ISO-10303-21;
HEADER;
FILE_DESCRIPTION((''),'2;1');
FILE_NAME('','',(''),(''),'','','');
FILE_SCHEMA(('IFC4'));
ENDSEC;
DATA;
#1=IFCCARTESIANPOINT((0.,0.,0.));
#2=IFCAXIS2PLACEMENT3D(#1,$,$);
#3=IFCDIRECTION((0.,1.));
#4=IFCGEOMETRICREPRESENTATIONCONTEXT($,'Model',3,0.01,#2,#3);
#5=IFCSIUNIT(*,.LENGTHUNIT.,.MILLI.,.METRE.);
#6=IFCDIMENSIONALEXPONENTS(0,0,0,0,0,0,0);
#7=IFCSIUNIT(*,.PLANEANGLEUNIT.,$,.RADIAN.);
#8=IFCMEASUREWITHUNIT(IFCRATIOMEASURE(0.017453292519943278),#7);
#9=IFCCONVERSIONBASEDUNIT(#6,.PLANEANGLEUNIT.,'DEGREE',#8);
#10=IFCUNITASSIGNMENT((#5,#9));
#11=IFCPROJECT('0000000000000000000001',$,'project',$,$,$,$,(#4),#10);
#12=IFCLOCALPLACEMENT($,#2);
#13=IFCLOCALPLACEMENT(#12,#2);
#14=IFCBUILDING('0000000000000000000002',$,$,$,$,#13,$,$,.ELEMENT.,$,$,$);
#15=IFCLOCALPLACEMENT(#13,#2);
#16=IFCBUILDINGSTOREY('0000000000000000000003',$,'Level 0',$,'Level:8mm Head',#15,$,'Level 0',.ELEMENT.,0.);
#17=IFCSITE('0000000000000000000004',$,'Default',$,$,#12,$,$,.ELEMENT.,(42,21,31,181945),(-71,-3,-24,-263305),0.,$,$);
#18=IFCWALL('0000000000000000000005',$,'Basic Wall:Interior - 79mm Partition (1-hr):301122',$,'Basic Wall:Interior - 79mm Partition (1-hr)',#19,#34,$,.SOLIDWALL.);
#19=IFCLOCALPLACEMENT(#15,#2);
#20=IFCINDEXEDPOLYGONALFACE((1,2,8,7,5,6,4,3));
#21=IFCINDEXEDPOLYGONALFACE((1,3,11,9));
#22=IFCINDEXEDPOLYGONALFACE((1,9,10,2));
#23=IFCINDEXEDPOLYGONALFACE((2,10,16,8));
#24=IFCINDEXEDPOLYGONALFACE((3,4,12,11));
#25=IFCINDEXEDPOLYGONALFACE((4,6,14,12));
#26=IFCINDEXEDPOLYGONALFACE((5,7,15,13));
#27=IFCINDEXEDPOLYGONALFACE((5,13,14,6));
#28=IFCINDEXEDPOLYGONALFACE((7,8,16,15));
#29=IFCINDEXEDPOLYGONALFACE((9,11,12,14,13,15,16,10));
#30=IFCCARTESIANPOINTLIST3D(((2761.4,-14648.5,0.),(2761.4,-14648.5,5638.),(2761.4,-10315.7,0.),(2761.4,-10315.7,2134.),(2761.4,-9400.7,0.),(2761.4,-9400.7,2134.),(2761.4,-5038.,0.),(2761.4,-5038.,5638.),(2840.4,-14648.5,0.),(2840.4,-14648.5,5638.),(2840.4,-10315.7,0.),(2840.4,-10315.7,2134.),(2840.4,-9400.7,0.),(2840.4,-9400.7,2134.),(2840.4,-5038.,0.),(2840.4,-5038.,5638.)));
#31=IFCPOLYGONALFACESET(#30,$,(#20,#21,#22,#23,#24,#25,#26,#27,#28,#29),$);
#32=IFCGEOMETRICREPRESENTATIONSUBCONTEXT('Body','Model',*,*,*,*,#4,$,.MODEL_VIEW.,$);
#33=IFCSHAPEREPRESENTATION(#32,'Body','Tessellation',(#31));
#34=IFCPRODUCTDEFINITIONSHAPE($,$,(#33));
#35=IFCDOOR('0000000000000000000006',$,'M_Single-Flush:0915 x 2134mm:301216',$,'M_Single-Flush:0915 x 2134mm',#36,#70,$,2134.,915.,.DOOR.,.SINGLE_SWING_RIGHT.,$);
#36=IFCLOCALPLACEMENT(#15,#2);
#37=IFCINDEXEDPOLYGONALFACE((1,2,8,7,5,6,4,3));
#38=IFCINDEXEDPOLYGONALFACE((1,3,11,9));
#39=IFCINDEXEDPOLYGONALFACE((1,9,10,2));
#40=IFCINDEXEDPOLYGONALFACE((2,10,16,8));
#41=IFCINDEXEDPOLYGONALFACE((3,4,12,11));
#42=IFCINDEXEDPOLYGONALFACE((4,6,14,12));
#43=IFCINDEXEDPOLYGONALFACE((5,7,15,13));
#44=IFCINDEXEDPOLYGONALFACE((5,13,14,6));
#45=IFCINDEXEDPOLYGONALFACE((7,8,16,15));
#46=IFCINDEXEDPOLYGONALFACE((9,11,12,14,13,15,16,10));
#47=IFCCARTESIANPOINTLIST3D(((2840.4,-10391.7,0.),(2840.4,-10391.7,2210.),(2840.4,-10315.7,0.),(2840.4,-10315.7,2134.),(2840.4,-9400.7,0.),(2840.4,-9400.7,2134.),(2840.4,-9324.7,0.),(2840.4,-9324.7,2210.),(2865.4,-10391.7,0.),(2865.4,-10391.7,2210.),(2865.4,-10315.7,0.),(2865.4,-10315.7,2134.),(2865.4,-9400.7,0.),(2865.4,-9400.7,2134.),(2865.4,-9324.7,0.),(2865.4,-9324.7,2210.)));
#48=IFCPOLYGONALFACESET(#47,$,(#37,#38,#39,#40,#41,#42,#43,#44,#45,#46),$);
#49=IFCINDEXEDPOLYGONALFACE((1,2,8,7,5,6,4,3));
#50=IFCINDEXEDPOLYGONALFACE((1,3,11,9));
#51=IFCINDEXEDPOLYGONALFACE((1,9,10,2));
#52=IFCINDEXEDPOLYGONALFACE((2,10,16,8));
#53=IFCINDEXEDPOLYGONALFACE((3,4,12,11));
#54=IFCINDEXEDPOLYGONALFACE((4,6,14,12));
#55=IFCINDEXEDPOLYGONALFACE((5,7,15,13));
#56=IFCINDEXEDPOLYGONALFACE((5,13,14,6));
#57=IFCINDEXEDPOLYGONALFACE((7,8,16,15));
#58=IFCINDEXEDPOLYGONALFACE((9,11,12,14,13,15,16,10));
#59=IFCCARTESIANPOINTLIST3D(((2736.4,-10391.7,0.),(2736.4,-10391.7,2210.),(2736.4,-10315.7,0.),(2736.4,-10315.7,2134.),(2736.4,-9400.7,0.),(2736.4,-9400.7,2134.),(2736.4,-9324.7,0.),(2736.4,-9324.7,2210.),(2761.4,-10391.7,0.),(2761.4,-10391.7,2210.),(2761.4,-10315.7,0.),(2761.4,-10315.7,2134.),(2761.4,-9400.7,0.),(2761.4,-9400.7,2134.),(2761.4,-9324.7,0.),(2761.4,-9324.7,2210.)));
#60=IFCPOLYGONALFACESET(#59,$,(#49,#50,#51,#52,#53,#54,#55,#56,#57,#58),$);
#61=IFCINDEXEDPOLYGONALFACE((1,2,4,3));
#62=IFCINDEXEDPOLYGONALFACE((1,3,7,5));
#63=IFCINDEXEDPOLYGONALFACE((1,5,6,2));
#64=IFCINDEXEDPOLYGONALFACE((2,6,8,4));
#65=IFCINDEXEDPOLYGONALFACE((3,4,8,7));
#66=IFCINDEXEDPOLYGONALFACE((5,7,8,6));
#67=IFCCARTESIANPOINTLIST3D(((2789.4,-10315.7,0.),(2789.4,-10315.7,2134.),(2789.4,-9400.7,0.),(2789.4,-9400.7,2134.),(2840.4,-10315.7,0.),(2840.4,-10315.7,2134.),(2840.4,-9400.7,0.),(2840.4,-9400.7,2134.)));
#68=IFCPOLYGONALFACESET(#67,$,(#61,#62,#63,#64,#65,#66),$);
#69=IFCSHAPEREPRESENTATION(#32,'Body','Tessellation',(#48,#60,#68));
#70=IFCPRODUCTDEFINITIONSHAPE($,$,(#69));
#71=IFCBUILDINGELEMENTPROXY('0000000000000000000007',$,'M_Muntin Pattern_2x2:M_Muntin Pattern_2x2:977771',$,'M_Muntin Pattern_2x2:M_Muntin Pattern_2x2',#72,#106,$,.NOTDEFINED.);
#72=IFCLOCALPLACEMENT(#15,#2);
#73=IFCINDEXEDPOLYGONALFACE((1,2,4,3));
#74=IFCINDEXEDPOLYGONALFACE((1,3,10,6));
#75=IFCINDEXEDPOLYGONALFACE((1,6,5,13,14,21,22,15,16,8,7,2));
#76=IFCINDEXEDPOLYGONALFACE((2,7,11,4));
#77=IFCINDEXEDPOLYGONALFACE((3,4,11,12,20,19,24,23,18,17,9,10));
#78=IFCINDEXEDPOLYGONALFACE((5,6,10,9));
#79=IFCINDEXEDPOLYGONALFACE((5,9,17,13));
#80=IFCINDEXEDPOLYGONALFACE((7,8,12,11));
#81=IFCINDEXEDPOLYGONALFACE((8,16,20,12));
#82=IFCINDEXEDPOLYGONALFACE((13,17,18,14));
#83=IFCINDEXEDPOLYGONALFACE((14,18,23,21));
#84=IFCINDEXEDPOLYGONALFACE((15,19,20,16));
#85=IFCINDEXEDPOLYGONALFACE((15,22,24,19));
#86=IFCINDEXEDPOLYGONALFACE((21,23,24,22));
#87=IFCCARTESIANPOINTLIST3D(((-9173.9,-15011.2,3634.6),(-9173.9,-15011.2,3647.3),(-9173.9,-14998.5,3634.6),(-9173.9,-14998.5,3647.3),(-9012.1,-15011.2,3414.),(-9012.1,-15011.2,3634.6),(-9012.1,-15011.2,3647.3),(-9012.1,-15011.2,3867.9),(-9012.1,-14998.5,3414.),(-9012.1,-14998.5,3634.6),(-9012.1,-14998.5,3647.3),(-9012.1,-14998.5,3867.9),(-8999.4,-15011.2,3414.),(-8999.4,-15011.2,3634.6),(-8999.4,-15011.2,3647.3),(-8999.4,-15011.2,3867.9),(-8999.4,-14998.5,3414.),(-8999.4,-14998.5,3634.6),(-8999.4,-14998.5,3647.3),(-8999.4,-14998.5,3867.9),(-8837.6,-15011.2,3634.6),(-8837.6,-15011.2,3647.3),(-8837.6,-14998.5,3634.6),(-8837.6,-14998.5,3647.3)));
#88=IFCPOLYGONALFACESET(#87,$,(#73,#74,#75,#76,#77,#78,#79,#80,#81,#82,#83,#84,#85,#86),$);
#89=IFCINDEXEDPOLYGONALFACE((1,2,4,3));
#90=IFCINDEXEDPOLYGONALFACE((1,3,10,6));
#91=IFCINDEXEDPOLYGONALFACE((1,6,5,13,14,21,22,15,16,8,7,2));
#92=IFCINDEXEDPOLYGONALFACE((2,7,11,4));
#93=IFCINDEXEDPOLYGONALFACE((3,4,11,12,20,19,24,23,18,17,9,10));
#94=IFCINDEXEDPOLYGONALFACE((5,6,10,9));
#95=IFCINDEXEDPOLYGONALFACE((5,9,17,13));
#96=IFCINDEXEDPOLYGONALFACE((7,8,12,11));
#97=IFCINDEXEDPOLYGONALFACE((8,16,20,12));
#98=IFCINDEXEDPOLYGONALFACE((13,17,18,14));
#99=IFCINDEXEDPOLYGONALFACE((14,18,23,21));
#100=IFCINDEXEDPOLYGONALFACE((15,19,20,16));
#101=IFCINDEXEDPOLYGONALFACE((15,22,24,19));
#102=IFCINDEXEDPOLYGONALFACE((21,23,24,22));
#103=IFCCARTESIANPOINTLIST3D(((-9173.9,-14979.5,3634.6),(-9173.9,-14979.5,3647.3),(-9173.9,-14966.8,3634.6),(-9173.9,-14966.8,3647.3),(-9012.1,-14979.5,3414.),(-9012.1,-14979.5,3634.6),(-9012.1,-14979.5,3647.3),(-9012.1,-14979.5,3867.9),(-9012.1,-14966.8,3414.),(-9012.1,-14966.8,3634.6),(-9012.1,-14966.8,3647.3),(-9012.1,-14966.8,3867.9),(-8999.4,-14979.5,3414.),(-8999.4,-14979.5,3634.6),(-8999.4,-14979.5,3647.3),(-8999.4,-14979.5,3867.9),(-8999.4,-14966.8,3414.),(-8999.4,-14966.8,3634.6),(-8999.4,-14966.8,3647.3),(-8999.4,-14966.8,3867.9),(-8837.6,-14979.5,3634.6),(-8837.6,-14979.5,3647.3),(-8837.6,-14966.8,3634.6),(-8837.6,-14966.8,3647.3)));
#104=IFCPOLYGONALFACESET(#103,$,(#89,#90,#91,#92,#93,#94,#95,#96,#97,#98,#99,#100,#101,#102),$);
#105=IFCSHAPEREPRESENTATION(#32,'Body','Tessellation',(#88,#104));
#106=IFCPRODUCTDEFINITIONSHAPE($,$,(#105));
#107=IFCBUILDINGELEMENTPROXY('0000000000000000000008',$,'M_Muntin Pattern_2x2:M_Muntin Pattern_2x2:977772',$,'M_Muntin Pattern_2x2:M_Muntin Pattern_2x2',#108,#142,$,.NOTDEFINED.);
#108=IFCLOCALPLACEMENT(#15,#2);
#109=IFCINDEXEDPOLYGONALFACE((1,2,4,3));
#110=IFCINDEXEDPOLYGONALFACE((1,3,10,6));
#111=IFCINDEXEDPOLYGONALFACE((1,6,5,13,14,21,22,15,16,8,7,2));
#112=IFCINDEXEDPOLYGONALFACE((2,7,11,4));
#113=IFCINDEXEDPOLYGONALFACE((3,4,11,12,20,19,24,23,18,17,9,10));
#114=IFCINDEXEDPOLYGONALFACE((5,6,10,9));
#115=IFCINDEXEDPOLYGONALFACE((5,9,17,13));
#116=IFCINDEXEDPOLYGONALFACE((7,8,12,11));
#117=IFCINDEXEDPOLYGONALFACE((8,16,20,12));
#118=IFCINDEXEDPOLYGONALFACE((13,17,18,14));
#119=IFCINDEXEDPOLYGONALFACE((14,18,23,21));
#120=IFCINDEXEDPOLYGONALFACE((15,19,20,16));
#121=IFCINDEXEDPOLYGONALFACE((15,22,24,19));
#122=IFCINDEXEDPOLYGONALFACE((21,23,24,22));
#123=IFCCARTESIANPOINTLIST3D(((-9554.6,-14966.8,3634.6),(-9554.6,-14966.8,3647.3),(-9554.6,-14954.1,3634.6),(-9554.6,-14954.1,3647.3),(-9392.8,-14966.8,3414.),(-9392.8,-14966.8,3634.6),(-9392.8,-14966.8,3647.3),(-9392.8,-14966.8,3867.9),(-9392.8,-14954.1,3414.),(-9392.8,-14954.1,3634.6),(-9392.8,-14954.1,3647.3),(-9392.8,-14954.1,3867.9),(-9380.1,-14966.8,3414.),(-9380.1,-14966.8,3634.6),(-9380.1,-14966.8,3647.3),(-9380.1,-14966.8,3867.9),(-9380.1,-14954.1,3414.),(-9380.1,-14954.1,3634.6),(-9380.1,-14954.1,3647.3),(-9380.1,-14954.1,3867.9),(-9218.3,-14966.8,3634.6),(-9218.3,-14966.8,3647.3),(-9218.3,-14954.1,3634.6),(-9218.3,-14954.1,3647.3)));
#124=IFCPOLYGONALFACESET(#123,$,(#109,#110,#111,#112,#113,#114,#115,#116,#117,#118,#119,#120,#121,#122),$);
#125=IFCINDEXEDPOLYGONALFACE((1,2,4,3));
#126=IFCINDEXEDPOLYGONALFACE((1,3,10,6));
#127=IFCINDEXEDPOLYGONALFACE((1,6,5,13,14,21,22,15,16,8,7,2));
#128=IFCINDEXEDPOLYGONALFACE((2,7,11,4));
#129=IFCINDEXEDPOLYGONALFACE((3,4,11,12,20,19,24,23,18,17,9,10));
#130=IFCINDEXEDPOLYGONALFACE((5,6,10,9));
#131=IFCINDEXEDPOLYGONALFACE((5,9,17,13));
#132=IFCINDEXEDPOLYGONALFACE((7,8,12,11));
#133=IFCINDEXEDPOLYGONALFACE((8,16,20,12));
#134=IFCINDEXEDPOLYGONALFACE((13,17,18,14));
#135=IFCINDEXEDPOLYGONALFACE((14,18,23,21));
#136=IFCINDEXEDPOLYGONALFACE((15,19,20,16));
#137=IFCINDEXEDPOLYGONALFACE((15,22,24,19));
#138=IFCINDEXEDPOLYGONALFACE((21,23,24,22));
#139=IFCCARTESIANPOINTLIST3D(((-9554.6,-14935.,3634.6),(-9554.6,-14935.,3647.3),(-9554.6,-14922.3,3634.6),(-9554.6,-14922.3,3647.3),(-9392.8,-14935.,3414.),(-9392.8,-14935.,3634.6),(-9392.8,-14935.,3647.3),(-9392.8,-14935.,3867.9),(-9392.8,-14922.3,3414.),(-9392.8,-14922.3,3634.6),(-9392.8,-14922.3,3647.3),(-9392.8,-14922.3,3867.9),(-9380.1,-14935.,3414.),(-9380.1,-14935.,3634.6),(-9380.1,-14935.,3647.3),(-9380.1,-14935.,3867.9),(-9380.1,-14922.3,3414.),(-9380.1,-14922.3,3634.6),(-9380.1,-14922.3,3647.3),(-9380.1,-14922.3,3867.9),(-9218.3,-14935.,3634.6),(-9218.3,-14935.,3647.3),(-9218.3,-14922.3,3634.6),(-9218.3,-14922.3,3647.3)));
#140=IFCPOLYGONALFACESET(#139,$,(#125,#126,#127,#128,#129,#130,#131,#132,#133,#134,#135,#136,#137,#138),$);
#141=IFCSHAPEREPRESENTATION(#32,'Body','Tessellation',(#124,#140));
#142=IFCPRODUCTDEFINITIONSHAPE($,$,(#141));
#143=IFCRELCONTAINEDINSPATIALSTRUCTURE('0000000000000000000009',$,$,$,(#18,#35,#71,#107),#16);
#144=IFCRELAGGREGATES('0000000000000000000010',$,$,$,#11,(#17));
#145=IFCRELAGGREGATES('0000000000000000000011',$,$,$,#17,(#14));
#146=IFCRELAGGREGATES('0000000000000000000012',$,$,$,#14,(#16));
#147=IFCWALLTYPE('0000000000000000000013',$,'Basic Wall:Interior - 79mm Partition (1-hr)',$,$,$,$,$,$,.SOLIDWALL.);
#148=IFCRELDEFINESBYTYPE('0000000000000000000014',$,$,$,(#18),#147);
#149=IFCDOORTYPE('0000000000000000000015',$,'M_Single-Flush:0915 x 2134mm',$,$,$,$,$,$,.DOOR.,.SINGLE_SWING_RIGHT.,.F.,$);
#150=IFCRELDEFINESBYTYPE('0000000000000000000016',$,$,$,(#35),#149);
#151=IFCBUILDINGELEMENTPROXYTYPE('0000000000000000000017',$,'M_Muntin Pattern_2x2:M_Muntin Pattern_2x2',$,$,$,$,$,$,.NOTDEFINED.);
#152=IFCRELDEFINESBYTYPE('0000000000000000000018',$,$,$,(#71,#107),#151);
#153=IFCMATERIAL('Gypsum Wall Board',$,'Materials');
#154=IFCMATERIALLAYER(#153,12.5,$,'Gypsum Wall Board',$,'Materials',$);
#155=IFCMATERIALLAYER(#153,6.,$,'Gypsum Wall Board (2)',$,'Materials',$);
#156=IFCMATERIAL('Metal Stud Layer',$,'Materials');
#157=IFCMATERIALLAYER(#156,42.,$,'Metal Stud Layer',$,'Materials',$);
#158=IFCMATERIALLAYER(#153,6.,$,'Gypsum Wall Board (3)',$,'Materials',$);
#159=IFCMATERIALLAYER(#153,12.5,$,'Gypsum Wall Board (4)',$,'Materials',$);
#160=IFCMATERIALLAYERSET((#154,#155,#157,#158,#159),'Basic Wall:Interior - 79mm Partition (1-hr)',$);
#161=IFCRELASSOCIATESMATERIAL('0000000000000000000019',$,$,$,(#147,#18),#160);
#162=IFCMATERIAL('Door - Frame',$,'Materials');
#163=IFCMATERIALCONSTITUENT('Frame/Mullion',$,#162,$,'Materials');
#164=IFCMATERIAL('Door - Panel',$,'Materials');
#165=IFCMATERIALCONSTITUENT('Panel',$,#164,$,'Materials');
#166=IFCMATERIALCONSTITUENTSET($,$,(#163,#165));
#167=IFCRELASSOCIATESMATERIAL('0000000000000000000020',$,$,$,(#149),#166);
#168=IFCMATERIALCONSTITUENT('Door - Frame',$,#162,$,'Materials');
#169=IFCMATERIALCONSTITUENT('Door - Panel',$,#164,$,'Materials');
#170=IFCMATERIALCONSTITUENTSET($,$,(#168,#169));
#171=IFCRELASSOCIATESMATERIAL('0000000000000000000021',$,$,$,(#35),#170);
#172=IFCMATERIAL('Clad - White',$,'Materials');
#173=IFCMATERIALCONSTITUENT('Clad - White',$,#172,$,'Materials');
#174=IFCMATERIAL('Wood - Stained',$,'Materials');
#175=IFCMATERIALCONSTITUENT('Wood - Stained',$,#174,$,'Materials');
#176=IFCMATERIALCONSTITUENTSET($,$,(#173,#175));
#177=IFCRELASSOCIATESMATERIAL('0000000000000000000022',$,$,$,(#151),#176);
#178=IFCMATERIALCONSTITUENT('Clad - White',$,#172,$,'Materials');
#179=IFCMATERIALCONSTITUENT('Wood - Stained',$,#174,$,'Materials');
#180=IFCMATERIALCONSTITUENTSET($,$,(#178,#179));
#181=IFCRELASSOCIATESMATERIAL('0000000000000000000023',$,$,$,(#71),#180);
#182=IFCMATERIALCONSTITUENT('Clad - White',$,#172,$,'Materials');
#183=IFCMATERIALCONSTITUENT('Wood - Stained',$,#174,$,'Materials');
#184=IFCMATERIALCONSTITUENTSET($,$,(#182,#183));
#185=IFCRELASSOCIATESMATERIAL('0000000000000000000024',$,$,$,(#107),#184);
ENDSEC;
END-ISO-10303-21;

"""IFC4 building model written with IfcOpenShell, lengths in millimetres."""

from ifc_helpers import new_model, entity, si_unit, converted_unit, direction, frame, frame_2d, origin, origin_2d_with_axis, place, context, subcontext, project, spatial, polyline, rectangle, outline, extrude, clip, bounded_halfspace, source, transform, mapped, material, layer, layer_set, layer_usage, constituent, constituent_set, type_object, type_shapes, element, fill, save


model = new_model("IFC4")

# Units and contexts
model_context = context("Model", 3, precision=0.01, world=origin(), true_north=direction((0.0, 1.0)))
body_context = subcontext(model_context, "Body", "Model", "MODEL_VIEW")
ifc_project = project(units=[si_unit("LENGTHUNIT", "METRE", prefix="MILLI"), converted_unit("PLANEANGLEUNIT", "DEGREE", entity("IfcRatioMeasure", 0.017453292519943278), si_unit("PLANEANGLEUNIT", "RADIAN"), dimensions=[0, 0, 0, 0, 0, 0, 0])], contexts=[model_context])

# Site, building, storey
site_placement = place(None, origin())
site = spatial("IfcSite", under=ifc_project, at=site_placement, Name="Default", CompositionType="ELEMENT", RefLatitude=(42, 21, 31, 181945), RefLongitude=(-71, -3, -24, -263305), RefElevation=0.0)
building_placement = place(site_placement, origin())
building = spatial("IfcBuilding", under=site, at=building_placement, CompositionType="ELEMENT")
storey_placement = place(building_placement, origin())
storey = spatial("IfcBuildingStorey", under=building, at=storey_placement, Name="Level 0", ObjectType="Level:8mm Head", LongName="Level 0", CompositionType="ELEMENT", Elevation=0.0)

# Shared definitions
ifc_material_1 = material(Name="Metal Stud Layer", Category="Materials")
ifc_material_2 = material(Name="Gypsum Wall Board", Category="Materials")
ifc_material_3 = material(Name="Door - Frame", Category="Materials")
ifc_material_4 = material(Name="Door - Panel", Category="Materials")

# Wall, opening, door
ifc_layer_1 = layer(ifc_material_2, 12.5, Name="Gypsum Wall Board", Category="Materials")
ifc_layer_2 = layer(ifc_material_2, 6.0, Name="Gypsum Wall Board (2)", Category="Materials")
ifc_layer_3 = layer(ifc_material_1, 42.0, Name="Metal Stud Layer", Category="Materials")
ifc_layer_4 = layer(ifc_material_2, 6.0, Name="Gypsum Wall Board (3)", Category="Materials")
ifc_layer_5 = layer(ifc_material_2, 12.5, Name="Gypsum Wall Board (4)", Category="Materials")
ifc_layer_set_1 = layer_set([ifc_layer_1, ifc_layer_2, ifc_layer_3, ifc_layer_4, ifc_layer_5], Name="Basic Wall:Interior - 79mm Partition (1-hr)")
ifc_layer_usage_1 = layer_usage(ifc_layer_set_1, "AXIS2", "NEGATIVE", 39.5)
wall_type_1 = type_object("IfcWallType", Name="Basic Wall:Interior - 79mm Partition (1-hr)", PredefinedType="SOLIDWALL", material=ifc_layer_set_1)
ifc_constituent_1 = constituent(ifc_material_3, Name="Frame/Mullion", Category="Materials")
ifc_constituent_2 = constituent(ifc_material_4, Name="Panel", Category="Materials")
ifc_constituent_set_1 = constituent_set(constituents=[ifc_constituent_1, ifc_constituent_2])
door_type_1 = type_object("IfcDoorType", Name="M_Single-Flush:0915 x 2134mm", OperationType="SINGLE_SWING_RIGHT", ParameterTakesPrecedence=False, PredefinedType="DOOR", material=ifc_constituent_set_1)
shared_shape_1 = source(origin(), body_context, "Body", "SweptSolid", [
    extrude(outline(polyline([(-533.5, -1124.0), (533.5, -1124.0), (533.5, 1086.0), (457.5, 1086.0), (457.5, -1048.0), (-457.5, -1048.0), (-457.5, 1086.0), (-533.5, 1086.0), (-533.5, -1124.0)])), frame((457.5, 79.0, 1086.0), z_axis=(0.0, 1.0, 0.0), x_axis=(1.0, 0.0, 0.0)), (0.0, 0.0, 1.0), 25.0),
    extrude(outline(polyline([(-1124.0, -533.5), (1086.0, -533.5), (1086.0, -457.5), (-1048.0, -457.5), (-1048.0, 457.5), (1086.0, 457.5), (1086.0, 533.5), (-1124.0, 533.5), (-1124.0, -533.5)])), frame((457.5, -25.0, 1086.0), z_axis=(0.0, 1.0, 0.0), x_axis=(0.0, 0.0, -1.0)), (0.0, 0.0, 1.0), 25.0),
    extrude(rectangle(XDim=51.0, YDim=915.0, at=origin_2d_with_axis()), frame((457.5, 53.5, 0.0), z_axis=(0.0, 0.0, 1.0), x_axis=(0.0, 1.0, 0.0)), (0.0, 0.0, 1.0), 2134.0),
])
type_shapes(door_type_1, [shared_shape_1])
wall_1_placement = place(storey_placement, frame((2800.9, -5038.0, 0.0), z_axis=(0.0, 0.0, 1.0), x_axis=(0.0, -1.0, 0.0)))
wall_1 = element("IfcWall", 1, at=wall_1_placement, inside=storey, type_object=wall_type_1, material=ifc_layer_usage_1, Name="Basic Wall:Interior - 79mm Partition (1-hr):301122", ObjectType="Basic Wall:Interior - 79mm Partition (1-hr)", PredefinedType="SOLIDWALL", context=body_context, shape_type="Clipping", body=[
    clip(extrude(rectangle(XDim=9610.5, YDim=79.0, at=frame_2d((4805.3, 0.0), x_axis=(-1.0, 0.0))), origin(), (0.0, 0.0, 1.0), 5638.0), bounded_halfspace(frame((0.0, -39.5, 5638.0), z_axis=(0.0, 0.0, -1.0), x_axis=(1.0, 0.0, 0.0)), True, frame((0.0, -39.5, 5638.0)), polyline([(0.0, 0.0), (2929280.4, 0.0), (2929280.4, 24079.2), (0.0, 24079.2), (0.0, 0.0)]))),
])
opening_1_placement = place(wall_1_placement, frame((4362.6, -39.5, 0.0)))
opening_1 = element("IfcOpeningElement", 2, at=opening_1_placement, cuts=wall_1, PredefinedType="OPENING", context=body_context, shape_type="SweptSolid", body=[
    extrude(rectangle(XDim=915.0, YDim=2134.0, at=frame_2d((1067.0, 457.5), x_axis=(0.0, 1.0))), frame((0.0, 0.0, 0.0), z_axis=(0.0, 1.0, 0.0), x_axis=(0.0, 0.0, 1.0)), (0.0, 0.0, 1.0), 79.0),
])
ifc_constituent_3 = constituent(ifc_material_3, Name="Door - Frame", Category="Materials")
ifc_constituent_4 = constituent(ifc_material_4, Name="Door - Panel", Category="Materials")
ifc_constituent_set_2 = constituent_set(constituents=[ifc_constituent_3, ifc_constituent_4])
door_1_placement = place(opening_1_placement, origin())
door_1 = element("IfcDoor", 3, at=door_1_placement, inside=storey, type_object=door_type_1, material=ifc_constituent_set_2, Name="M_Single-Flush:0915 x 2134mm:301216", ObjectType="M_Single-Flush:0915 x 2134mm", OperationType="SINGLE_SWING_RIGHT", OverallHeight=2134.0, OverallWidth=915.0, PredefinedType="DOOR", context=body_context, shape_type="MappedRepresentation", body=[
    mapped(shared_shape_1, transform((0.0, 0.0, 0.0), scale=1.0)),
])
fill(opening_1, door_1)

# Building element proxies
ifc_material_5 = material(Name="Clad - White", Category="Materials")
ifc_constituent_5 = constituent(ifc_material_5, Name="Clad - White", Category="Materials")
ifc_material_6 = material(Name="Wood - Stained", Category="Materials")
ifc_constituent_6 = constituent(ifc_material_6, Name="Wood - Stained", Category="Materials")
ifc_constituent_set_3 = constituent_set(constituents=[ifc_constituent_5, ifc_constituent_6])
ifc_constituent_7 = constituent(ifc_material_5, Name="Clad - White", Category="Materials")
ifc_constituent_8 = constituent(ifc_material_6, Name="Wood - Stained", Category="Materials")
ifc_constituent_set_4 = constituent_set(constituents=[ifc_constituent_7, ifc_constituent_8])
building_element_proxy_type_1 = type_object("IfcBuildingElementProxyType", Name="M_Muntin Pattern_2x2:M_Muntin Pattern_2x2", PredefinedType="NOTDEFINED", material=ifc_constituent_set_4)
shared_shape_2 = source(origin(), body_context, "Body", "SweptSolid", [
    extrude(outline(polyline([(6.4, -6.4), (227.0, -6.4), (227.0, 6.3), (6.4, 6.3), (6.4, 168.2), (-6.3, 168.2), (-6.3, 6.3), (-227.0, 6.3), (-227.0, -6.4), (-6.3, -6.4), (-6.3, -168.1), (6.4, -168.1), (6.4, -6.4)])), frame((0.0, 9.5, 227.0), z_axis=(0.0, 1.0, 0.0), x_axis=(0.0, 0.0, 1.0)), (0.0, 0.0, 1.0), 12.7),
    extrude(outline(polyline([(6.4, -6.4), (227.0, -6.4), (227.0, 6.3), (6.4, 6.3), (6.4, 168.2), (-6.3, 168.2), (-6.3, 6.3), (-227.0, 6.3), (-227.0, -6.4), (-6.3, -6.4), (-6.3, -168.1), (6.4, -168.1), (6.4, -6.4)])), frame((0.0, -22.2, 227.0), z_axis=(0.0, 1.0, 0.0), x_axis=(0.0, 0.0, 1.0)), (0.0, 0.0, 1.0), 12.7),
])
type_shapes(building_element_proxy_type_1, [shared_shape_2])
proxy_1_placement = place(storey_placement, frame((-9005.7, -14989.0, 3414.0), z_axis=(0.0, 0.0, 1.0), x_axis=(-1.0, 0.0, 0.0)))
element("IfcBuildingElementProxy", 4, at=proxy_1_placement, inside=storey, type_object=building_element_proxy_type_1, material=ifc_constituent_set_3, Name="M_Muntin Pattern_2x2:M_Muntin Pattern_2x2:977771", ObjectType="M_Muntin Pattern_2x2:M_Muntin Pattern_2x2", PredefinedType="NOTDEFINED", context=body_context, shape_type="MappedRepresentation", body=[
    mapped(shared_shape_2, transform((0.0, 0.0, 0.0), scale=1.0)),
])
ifc_constituent_9 = constituent(ifc_material_5, Name="Clad - White", Category="Materials")
ifc_constituent_10 = constituent(ifc_material_6, Name="Wood - Stained", Category="Materials")
ifc_constituent_set_5 = constituent_set(constituents=[ifc_constituent_9, ifc_constituent_10])
proxy_2_placement = place(storey_placement, frame((-9386.5, -14944.6, 3414.0), z_axis=(0.0, 0.0, 1.0), x_axis=(-1.0, 0.0, 0.0)))
element("IfcBuildingElementProxy", 5, at=proxy_2_placement, inside=storey, type_object=building_element_proxy_type_1, material=ifc_constituent_set_5, Name="M_Muntin Pattern_2x2:M_Muntin Pattern_2x2:977772", ObjectType="M_Muntin Pattern_2x2:M_Muntin Pattern_2x2", PredefinedType="NOTDEFINED", context=body_context, shape_type="MappedRepresentation", body=[
    mapped(shared_shape_2, transform((0.0, 0.0, 0.0), scale=1.0)),
])

save(model, "model.ifc")
